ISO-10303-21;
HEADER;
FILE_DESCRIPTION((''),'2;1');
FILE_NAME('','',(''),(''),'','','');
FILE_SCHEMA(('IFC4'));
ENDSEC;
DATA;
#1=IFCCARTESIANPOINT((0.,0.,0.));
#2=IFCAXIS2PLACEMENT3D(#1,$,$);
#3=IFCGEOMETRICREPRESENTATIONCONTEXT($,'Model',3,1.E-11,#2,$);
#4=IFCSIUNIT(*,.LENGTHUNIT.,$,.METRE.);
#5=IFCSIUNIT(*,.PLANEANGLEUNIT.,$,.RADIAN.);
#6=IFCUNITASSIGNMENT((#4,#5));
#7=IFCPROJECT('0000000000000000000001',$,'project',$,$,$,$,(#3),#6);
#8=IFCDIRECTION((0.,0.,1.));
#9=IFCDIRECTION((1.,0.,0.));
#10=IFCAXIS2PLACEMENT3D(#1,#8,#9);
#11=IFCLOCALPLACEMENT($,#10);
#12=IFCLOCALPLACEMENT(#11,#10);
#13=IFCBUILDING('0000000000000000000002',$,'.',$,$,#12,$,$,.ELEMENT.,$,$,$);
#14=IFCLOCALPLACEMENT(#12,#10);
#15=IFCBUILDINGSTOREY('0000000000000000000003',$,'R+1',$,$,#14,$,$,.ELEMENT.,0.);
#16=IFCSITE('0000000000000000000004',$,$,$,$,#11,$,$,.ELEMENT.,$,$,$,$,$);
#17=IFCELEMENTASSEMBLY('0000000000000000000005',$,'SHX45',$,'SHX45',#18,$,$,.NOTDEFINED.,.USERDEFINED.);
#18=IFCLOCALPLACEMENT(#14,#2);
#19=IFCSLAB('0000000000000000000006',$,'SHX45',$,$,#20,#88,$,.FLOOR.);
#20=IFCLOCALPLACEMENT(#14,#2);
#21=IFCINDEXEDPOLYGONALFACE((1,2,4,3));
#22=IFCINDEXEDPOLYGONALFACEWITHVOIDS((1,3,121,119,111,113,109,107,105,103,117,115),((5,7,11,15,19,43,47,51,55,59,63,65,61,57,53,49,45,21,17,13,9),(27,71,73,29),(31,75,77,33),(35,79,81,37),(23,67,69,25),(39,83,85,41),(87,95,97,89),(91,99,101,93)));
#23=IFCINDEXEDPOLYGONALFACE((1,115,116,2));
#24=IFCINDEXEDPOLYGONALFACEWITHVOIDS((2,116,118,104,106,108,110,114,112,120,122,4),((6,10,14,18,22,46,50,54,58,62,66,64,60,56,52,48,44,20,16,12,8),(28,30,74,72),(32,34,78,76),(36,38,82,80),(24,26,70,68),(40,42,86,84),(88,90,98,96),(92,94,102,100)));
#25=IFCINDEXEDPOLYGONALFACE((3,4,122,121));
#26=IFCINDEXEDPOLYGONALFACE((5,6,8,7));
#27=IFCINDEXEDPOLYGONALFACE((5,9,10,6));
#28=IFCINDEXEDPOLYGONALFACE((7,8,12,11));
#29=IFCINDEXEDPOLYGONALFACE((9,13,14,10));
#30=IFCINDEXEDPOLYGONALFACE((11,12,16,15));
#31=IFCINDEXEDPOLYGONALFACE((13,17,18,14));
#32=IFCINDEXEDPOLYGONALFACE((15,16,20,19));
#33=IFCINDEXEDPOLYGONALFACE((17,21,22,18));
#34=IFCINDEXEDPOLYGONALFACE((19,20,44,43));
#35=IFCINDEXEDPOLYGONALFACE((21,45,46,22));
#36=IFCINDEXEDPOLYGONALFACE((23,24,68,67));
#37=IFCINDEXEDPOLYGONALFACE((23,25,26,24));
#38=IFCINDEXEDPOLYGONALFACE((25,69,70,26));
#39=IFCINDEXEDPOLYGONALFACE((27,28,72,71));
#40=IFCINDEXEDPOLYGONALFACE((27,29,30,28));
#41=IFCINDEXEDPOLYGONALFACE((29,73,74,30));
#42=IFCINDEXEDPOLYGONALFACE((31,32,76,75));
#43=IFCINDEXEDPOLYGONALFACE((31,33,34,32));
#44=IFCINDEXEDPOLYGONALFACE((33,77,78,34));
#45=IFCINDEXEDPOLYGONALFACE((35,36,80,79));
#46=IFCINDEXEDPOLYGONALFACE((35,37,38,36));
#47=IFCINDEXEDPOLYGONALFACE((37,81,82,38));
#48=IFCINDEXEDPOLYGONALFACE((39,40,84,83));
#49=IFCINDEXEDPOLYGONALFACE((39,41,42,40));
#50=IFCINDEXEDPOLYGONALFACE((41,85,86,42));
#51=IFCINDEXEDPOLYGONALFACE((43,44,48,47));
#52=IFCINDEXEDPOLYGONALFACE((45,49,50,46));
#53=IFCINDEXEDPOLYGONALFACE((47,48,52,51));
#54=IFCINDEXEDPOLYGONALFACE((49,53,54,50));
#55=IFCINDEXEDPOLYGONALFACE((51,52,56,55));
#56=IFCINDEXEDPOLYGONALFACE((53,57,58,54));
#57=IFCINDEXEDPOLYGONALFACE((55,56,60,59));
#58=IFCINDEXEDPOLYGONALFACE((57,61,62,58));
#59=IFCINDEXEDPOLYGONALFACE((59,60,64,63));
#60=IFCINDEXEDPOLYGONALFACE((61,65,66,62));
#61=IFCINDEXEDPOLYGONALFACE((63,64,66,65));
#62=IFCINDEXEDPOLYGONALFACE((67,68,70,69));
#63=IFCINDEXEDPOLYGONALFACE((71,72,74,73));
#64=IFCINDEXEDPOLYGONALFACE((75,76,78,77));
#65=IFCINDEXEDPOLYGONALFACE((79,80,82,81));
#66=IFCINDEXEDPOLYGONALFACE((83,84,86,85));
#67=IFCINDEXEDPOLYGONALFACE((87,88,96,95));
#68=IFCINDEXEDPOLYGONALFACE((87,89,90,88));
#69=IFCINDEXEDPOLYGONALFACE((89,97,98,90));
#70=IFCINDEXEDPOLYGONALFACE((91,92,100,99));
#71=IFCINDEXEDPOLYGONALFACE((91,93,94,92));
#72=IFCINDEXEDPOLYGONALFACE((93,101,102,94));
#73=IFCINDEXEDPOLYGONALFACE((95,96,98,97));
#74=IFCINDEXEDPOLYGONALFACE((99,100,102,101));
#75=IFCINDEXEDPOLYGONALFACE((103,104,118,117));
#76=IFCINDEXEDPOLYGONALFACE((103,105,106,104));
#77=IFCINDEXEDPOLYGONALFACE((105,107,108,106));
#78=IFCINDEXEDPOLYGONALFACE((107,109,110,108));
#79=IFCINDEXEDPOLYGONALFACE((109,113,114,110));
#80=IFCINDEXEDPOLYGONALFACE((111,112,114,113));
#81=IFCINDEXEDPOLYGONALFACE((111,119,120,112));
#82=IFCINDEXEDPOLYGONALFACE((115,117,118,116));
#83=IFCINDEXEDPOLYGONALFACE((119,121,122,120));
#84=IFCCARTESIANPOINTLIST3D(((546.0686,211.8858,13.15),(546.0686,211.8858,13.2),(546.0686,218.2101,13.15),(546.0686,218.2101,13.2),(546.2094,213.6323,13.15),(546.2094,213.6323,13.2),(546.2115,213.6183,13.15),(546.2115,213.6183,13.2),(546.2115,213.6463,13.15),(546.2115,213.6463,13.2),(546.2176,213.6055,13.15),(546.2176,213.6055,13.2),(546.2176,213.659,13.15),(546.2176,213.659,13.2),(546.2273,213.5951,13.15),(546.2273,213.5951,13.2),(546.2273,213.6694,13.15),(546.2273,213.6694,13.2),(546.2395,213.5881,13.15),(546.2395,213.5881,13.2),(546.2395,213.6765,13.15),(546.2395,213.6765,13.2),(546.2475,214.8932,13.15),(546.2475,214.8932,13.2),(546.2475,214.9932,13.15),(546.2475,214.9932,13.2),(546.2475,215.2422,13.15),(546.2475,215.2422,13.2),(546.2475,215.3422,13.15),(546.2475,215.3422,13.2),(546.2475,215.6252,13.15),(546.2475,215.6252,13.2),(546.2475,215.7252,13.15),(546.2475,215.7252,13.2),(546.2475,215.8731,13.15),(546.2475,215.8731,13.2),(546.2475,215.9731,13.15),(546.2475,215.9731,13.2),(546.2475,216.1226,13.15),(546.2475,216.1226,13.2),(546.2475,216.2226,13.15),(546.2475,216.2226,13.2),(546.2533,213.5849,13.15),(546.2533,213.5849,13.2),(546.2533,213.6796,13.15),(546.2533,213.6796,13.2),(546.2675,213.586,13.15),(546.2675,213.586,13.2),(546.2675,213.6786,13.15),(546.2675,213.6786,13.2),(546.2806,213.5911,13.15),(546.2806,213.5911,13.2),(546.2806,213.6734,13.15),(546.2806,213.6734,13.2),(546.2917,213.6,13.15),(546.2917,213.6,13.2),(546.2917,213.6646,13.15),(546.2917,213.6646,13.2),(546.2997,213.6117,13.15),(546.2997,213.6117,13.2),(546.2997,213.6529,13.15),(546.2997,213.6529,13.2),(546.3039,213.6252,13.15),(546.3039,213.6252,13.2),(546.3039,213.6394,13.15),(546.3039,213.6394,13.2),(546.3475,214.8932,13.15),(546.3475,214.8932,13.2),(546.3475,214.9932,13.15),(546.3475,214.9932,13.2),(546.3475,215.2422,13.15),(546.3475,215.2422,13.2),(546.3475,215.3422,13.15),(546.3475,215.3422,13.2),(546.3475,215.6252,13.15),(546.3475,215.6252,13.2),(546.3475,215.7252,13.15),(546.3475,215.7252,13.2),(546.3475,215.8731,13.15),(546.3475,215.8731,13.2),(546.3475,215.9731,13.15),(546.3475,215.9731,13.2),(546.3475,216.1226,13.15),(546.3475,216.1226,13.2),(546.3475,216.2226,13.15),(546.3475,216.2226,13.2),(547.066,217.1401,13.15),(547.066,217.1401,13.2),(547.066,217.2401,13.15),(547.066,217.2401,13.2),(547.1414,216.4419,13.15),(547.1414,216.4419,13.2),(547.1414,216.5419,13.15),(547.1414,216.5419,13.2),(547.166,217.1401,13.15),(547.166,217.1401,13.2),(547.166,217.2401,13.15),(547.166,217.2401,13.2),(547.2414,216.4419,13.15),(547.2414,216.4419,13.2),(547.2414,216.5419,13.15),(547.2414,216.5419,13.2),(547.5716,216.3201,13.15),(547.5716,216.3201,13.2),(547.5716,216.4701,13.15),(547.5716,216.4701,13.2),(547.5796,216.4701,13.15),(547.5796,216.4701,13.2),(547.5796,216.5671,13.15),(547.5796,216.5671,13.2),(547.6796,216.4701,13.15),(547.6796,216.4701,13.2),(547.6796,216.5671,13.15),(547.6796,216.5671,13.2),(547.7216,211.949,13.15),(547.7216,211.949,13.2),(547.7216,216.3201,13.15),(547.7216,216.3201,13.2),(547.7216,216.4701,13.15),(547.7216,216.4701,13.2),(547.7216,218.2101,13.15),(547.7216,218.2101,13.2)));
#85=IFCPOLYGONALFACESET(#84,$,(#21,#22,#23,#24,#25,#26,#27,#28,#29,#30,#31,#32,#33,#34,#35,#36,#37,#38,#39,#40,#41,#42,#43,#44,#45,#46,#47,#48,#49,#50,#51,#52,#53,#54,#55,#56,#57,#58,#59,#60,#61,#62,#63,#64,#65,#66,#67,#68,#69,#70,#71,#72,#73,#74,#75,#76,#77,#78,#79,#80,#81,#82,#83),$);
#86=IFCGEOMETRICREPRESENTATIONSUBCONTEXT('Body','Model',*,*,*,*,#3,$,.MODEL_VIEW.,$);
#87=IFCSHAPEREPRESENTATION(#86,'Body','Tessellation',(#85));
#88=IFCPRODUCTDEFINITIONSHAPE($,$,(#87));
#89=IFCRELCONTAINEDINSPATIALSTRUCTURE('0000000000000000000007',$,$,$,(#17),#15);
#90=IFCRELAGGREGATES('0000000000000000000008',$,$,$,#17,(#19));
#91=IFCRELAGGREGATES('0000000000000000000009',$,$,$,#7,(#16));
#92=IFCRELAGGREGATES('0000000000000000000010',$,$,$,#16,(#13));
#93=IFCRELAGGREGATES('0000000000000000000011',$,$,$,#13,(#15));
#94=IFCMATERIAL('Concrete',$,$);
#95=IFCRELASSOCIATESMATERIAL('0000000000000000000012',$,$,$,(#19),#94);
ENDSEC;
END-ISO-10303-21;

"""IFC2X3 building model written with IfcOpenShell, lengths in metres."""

from ifc_helpers import new_model, si_unit, frame, origin, origin_with_axes, origin_2d_with_axis, place, context, subcontext, project, spatial, polyline, circle, outline, extrude, material, element, aggregate, save


model = new_model("IFC2X3")

# Units and contexts
model_context = context("Model", 3, precision=1e-11, world=origin())
body_context = subcontext(model_context, "Body", "Model", "MODEL_VIEW")
ifc_project = project(units=[si_unit("LENGTHUNIT", "METRE"), si_unit("PLANEANGLEUNIT", "RADIAN")], contexts=[model_context])

# Site, building, storey
site_placement = place(None, origin_with_axes())
site = spatial("IfcSite", under=ifc_project, at=site_placement, CompositionType="ELEMENT")
building_placement = place(site_placement, origin_with_axes())
building = spatial("IfcBuilding", under=site, at=building_placement, Name=".", CompositionType="ELEMENT")
storey_placement = place(building_placement, origin_with_axes())
storey = spatial("IfcBuildingStorey", under=building, at=storey_placement, Name="R+1", CompositionType="ELEMENT", Elevation=0.0)

# Element assembly, slab, openings
assembly_1_placement = place(storey_placement, origin_with_axes())
assembly_1 = element("IfcElementAssembly", 1, at=assembly_1_placement, inside=storey, Name="SHX45", ObjectType="SHX45", AssemblyPlace="NOTDEFINED", PredefinedType="USERDEFINED")
ifc_material = material(Name="Concrete")
slab_placement = place(assembly_1_placement, frame((547.7216, 211.8858, 13.15), z_axis=(0.0, 0.0, 1.0), x_axis=(0.0, 1.0, 0.0)))
slab = element("IfcSlab", 2, at=slab_placement, material=ifc_material, Name="SHX45", PredefinedType="FLOOR", context=body_context, shape_type="SweptSolid", body=[
    extrude(outline(polyline([(0.0, -0.0631), (0.0, -6.3243), (1.6531, -6.3243), (1.653, 0.0), (0.0, -0.0631)])), frame((0.0, 0.0, 0.0), z_axis=(0.0, 0.0, 1.0), x_axis=(0.0, 1.0, 0.0)), (0.0, 0.0, 1.0), 0.05),
])
opening_1_placement = place(slab_placement, origin_with_axes())
element("IfcOpeningElement", 3, at=opening_1_placement, cuts=slab, ObjectType="Opening", context=body_context, shape_type="SweptSolid", body=[
    extrude(outline(polyline([(0.0, -4.4343), (0.0, -4.5843), (0.15, -4.5843), (0.15, -4.4343), (0.0, -4.4343)])), frame((0.0, 0.0, 0.0), z_axis=(0.0, 0.0, 1.0), x_axis=(0.0, 1.0, 0.0)), (0.0, 0.0, 1.0), 0.05),
])
opening_2_placement = place(slab_placement, frame((1.7465, 1.4647, 0.0), z_axis=(0.0, 0.0, 1.0), x_axis=(1.0, 0.0, 0.0)))
element("IfcOpeningElement", 4, at=opening_2_placement, cuts=slab, ObjectType="Opening", context=body_context, shape_type="SweptSolid", body=[
    extrude(circle(Radius=0.0475, at=origin_2d_with_axis()), frame((0.0, 0.0, 0.0), z_axis=(0.0, 0.0, 1.0), x_axis=(0.0, 1.0, 0.0)), (0.0, 0.0, 1.0), 0.05),
])
opening_3_placement = place(slab_placement, origin_with_axes())
element("IfcOpeningElement", 5, at=opening_3_placement, cuts=slab, ObjectType="Opening", context=body_context, shape_type="SweptSolid", body=[
    extrude(outline(polyline([(0.042, -4.5812), (0.042, -4.6812), (0.142, -4.6812), (0.142, -4.5812), (0.042, -4.5812)])), frame((0.0, 0.0, 0.0), z_axis=(0.0, 0.0, 1.0), x_axis=(0.0, 1.0, 0.0)), (0.0, 0.0, 1.0), 0.05),
])
opening_4_placement = place(slab_placement, origin_with_axes())
element("IfcOpeningElement", 6, at=opening_4_placement, cuts=slab, ObjectType="Opening", context=body_context, shape_type="SweptSolid", body=[
    extrude(outline(polyline([(0.5556, -5.2543), (0.5556, -5.3543), (0.6556, -5.3543), (0.6556, -5.2543), (0.5556, -5.2543)])), frame((0.0, 0.0, 0.0), z_axis=(0.0, 0.0, 1.0), x_axis=(0.0, 1.0, 0.0)), (0.0, 0.0, 1.0), 0.05),
])
opening_5_placement = place(slab_placement, origin_with_axes())
element("IfcOpeningElement", 7, at=opening_5_placement, cuts=slab, ObjectType="Opening", context=body_context, shape_type="SweptSolid", body=[
    extrude(outline(polyline([(0.4802, -4.5561), (0.4802, -4.6561), (0.5802, -4.6561), (0.5802, -4.5561), (0.4802, -4.5561)])), frame((0.0, 0.0, 0.0), z_axis=(0.0, 0.0, 1.0), x_axis=(0.0, 1.0, 0.0)), (0.0, 0.0, 1.0), 0.05),
])
opening_6_placement = place(slab_placement, origin_with_axes())
element("IfcOpeningElement", 8, at=opening_6_placement, cuts=slab, ObjectType="Opening", context=body_context, shape_type="SweptSolid", body=[
    extrude(outline(polyline([(1.3741, -4.2368), (1.3741, -4.3368), (1.4741, -4.3368), (1.4741, -4.2368), (1.3741, -4.2368)])), frame((0.0, 0.0, 0.0), z_axis=(0.0, 0.0, 1.0), x_axis=(0.0, 1.0, 0.0)), (0.0, 0.0, 1.0), 0.05),
])
opening_7_placement = place(slab_placement, origin_with_axes())
element("IfcOpeningElement", 9, at=opening_7_placement, cuts=slab, ObjectType="Opening", context=body_context, shape_type="SweptSolid", body=[
    extrude(outline(polyline([(1.3741, -3.9873), (1.3741, -4.0873), (1.4741, -4.0873), (1.4741, -3.9873), (1.3741, -3.9873)])), frame((0.0, 0.0, 0.0), z_axis=(0.0, 0.0, 1.0), x_axis=(0.0, 1.0, 0.0)), (0.0, 0.0, 1.0), 0.05),
])
opening_8_placement = place(slab_placement, origin_with_axes())
element("IfcOpeningElement", 10, at=opening_8_placement, cuts=slab, ObjectType="Opening", context=body_context, shape_type="SweptSolid", body=[
    extrude(outline(polyline([(1.3741, -3.7393), (1.3741, -3.8393), (1.4741, -3.8393), (1.4741, -3.7393), (1.3741, -3.7393)])), frame((0.0, 0.0, 0.0), z_axis=(0.0, 0.0, 1.0), x_axis=(0.0, 1.0, 0.0)), (0.0, 0.0, 1.0), 0.05),
])
opening_9_placement = place(slab_placement, origin_with_axes())
element("IfcOpeningElement", 11, at=opening_9_placement, cuts=slab, ObjectType="Opening", context=body_context, shape_type="SweptSolid", body=[
    extrude(outline(polyline([(1.3741, -3.3564), (1.3741, -3.4564), (1.4741, -3.4564), (1.4741, -3.3564), (1.3741, -3.3564)])), frame((0.0, 0.0, 0.0), z_axis=(0.0, 0.0, 1.0), x_axis=(0.0, 1.0, 0.0)), (0.0, 0.0, 1.0), 0.05),
])
opening_10_placement = place(slab_placement, origin_with_axes())
element("IfcOpeningElement", 12, at=opening_10_placement, cuts=slab, ObjectType="Opening", context=body_context, shape_type="SweptSolid", body=[
    extrude(outline(polyline([(1.3741, -3.0074), (1.3741, -3.1074), (1.4741, -3.1074), (1.4741, -3.0074), (1.3741, -3.0074)])), frame((0.0, 0.0, 0.0), z_axis=(0.0, 0.0, 1.0), x_axis=(0.0, 1.0, 0.0)), (0.0, 0.0, 1.0), 0.05),
])
aggregate(assembly_1, [slab])

save(model, "model.ifc")
